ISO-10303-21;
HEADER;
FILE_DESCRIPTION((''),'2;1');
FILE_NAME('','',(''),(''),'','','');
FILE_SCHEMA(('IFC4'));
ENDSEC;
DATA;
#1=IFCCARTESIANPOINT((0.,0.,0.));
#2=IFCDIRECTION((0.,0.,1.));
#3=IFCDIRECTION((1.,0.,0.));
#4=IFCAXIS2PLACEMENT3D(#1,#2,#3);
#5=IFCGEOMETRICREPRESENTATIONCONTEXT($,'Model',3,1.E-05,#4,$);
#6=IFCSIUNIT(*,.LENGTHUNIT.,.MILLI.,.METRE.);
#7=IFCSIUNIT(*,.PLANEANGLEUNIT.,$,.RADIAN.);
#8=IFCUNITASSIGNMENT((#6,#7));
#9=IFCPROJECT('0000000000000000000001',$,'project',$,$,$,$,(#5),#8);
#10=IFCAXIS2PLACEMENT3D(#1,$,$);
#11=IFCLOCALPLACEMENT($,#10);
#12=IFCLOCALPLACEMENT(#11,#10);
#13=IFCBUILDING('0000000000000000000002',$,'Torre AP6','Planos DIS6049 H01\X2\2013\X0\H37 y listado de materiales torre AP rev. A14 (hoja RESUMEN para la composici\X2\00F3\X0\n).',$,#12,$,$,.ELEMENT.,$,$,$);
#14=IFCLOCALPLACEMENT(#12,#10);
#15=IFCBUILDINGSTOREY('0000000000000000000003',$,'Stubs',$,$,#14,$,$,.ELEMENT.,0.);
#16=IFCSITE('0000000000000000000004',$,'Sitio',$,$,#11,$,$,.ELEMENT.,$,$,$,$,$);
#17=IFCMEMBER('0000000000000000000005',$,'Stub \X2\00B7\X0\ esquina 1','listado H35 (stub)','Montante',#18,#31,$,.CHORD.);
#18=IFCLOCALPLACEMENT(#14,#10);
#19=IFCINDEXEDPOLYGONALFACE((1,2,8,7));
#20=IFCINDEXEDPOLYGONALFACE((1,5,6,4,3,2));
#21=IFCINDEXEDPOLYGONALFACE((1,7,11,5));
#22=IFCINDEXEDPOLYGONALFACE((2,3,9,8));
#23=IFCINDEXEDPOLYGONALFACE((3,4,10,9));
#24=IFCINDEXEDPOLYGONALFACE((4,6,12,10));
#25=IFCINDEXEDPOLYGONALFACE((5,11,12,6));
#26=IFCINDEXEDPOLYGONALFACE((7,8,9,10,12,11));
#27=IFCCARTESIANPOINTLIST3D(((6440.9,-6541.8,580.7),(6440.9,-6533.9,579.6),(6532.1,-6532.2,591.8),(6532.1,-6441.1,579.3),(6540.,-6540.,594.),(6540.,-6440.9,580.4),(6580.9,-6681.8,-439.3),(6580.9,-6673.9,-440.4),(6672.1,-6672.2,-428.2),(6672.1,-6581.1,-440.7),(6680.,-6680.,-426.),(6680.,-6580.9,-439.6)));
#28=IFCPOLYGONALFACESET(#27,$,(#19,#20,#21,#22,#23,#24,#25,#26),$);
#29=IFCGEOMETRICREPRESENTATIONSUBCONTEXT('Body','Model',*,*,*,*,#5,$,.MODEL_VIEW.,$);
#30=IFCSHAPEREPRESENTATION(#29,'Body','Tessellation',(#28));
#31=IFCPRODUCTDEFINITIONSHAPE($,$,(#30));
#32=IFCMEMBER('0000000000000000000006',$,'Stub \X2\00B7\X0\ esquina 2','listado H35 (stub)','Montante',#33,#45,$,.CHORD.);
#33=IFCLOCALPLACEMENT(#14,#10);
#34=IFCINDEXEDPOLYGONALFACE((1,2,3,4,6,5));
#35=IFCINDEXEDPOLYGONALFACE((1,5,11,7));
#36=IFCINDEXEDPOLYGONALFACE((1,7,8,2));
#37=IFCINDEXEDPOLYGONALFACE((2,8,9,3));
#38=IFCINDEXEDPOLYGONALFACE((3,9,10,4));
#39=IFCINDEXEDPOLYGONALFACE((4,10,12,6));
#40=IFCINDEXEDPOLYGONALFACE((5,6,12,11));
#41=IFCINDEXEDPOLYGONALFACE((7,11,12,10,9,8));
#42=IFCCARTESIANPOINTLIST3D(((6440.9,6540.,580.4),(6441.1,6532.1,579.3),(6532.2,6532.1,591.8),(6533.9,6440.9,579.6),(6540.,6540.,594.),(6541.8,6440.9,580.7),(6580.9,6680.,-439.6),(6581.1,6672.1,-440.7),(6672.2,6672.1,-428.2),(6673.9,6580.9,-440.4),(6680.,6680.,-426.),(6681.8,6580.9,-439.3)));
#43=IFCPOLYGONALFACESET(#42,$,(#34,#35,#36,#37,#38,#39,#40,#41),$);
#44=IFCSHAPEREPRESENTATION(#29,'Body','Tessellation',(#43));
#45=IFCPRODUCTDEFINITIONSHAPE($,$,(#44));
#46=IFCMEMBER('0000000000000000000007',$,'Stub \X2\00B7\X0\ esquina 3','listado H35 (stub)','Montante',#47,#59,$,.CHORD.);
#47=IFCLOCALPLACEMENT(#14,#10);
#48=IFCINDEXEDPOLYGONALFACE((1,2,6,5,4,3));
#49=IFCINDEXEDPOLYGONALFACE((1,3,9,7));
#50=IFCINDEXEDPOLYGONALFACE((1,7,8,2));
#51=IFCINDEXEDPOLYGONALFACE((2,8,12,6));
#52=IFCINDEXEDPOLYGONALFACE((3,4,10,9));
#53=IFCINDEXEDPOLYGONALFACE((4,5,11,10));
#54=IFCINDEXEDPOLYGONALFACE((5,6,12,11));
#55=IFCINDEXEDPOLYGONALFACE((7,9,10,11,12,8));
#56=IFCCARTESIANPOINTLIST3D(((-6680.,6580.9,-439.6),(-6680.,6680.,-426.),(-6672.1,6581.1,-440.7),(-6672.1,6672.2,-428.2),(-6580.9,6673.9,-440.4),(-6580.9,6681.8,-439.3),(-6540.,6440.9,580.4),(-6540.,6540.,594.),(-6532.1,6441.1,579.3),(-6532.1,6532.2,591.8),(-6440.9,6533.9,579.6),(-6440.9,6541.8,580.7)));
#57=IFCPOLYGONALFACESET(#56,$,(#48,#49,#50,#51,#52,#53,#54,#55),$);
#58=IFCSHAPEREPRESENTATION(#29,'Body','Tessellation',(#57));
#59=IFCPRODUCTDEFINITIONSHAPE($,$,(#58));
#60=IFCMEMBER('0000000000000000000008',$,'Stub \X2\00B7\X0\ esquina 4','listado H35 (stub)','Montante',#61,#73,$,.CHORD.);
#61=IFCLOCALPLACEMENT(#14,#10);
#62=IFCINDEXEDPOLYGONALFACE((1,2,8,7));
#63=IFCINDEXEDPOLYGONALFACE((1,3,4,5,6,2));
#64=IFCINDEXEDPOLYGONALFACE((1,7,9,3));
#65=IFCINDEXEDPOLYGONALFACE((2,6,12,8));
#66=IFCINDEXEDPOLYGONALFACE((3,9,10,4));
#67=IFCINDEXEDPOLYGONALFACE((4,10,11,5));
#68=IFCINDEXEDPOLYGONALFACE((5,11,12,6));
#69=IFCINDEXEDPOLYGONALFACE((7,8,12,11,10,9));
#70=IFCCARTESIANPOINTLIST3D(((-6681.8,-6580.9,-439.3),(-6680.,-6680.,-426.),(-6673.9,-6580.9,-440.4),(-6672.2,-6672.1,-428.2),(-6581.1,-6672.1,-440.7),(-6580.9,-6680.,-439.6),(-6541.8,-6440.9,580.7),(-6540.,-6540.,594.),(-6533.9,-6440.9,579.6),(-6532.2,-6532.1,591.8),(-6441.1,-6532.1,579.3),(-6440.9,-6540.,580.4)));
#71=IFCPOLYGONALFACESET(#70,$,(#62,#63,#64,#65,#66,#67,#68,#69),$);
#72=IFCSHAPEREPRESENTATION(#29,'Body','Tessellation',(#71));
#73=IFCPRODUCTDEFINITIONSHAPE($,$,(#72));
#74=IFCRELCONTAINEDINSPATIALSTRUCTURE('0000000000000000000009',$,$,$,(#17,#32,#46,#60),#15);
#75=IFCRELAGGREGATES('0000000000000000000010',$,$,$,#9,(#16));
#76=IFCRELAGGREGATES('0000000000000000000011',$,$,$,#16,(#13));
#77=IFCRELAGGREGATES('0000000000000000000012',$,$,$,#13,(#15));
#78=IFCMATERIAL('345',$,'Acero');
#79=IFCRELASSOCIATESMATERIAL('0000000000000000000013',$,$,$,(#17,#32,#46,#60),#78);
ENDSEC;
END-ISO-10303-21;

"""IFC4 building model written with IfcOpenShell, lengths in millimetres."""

from ifc_helpers import new_model, si_unit, frame, frame_2d, origin, origin_with_axes, place, context, subcontext, project, spatial, l_section, extrude, material, element, save


model = new_model("IFC4")

# Units and contexts
model_context = context("Model", 3, precision=1e-05, world=origin_with_axes())
body_context = subcontext(model_context, "Body", "Model", "MODEL_VIEW")
ifc_project = project(units=[si_unit("LENGTHUNIT", "METRE", prefix="MILLI"), si_unit("PLANEANGLEUNIT", "RADIAN")], contexts=[model_context])

# Site, building, storey
site_placement = place(None, origin())
site = spatial("IfcSite", under=ifc_project, at=site_placement, Name="Sitio", CompositionType="ELEMENT")
building_placement = place(site_placement, origin())
building = spatial("IfcBuilding", under=site, at=building_placement, Name="Torre AP6", Description="Planos DIS6049 H01–H37 y listado de materiales torre AP rev. A14 (hoja RESUMEN para la composición).", CompositionType="ELEMENT")
storey_placement = place(building_placement, origin())
storey = spatial("IfcBuildingStorey", under=building, at=storey_placement, Name="Stubs", CompositionType="ELEMENT", Elevation=0.0)

# Members
ifc_material = material(Name="345", Category="Acero")
for number, where, z_axis, x_axis, name in (
    (1, (6540.0, -6540.0, 594.0), (0.13474, -0.13474, -0.981677), (-0.990881, -0.018322, -0.133488), "Stub · esquina 1"),
    (2, (6540.0, 6540.0, 594.0), (0.13474, 0.13474, -0.981677), (0.018322, -0.990881, -0.133488), "Stub · esquina 2"),
    (3, (-6540.0, 6540.0, 594.0), (-0.13474, 0.13474, -0.981677), (0.990881, 0.018322, -0.133488), "Stub · esquina 3"),
    (4, (-6540.0, -6540.0, 594.0), (-0.13474, -0.13474, -0.981677), (-0.018322, 0.990881, -0.133488), "Stub · esquina 4"),
):
    element("IfcMember", number, at=place(storey_placement, frame(where, z_axis=z_axis, x_axis=x_axis)), inside=storey, material=ifc_material, Name=name, Description="listado H35 (stub)", ObjectType="Montante", PredefinedType="CHORD", context=body_context, shape_type="SweptSolid", body=[
        extrude(l_section(Depth=100.0, Width=100.0, Thickness=8.0, at=frame_2d((50.0, 50.0))), None, (0.0, 0.0, 1.0), 1039.0),
    ])

save(model, "model.ifc")
